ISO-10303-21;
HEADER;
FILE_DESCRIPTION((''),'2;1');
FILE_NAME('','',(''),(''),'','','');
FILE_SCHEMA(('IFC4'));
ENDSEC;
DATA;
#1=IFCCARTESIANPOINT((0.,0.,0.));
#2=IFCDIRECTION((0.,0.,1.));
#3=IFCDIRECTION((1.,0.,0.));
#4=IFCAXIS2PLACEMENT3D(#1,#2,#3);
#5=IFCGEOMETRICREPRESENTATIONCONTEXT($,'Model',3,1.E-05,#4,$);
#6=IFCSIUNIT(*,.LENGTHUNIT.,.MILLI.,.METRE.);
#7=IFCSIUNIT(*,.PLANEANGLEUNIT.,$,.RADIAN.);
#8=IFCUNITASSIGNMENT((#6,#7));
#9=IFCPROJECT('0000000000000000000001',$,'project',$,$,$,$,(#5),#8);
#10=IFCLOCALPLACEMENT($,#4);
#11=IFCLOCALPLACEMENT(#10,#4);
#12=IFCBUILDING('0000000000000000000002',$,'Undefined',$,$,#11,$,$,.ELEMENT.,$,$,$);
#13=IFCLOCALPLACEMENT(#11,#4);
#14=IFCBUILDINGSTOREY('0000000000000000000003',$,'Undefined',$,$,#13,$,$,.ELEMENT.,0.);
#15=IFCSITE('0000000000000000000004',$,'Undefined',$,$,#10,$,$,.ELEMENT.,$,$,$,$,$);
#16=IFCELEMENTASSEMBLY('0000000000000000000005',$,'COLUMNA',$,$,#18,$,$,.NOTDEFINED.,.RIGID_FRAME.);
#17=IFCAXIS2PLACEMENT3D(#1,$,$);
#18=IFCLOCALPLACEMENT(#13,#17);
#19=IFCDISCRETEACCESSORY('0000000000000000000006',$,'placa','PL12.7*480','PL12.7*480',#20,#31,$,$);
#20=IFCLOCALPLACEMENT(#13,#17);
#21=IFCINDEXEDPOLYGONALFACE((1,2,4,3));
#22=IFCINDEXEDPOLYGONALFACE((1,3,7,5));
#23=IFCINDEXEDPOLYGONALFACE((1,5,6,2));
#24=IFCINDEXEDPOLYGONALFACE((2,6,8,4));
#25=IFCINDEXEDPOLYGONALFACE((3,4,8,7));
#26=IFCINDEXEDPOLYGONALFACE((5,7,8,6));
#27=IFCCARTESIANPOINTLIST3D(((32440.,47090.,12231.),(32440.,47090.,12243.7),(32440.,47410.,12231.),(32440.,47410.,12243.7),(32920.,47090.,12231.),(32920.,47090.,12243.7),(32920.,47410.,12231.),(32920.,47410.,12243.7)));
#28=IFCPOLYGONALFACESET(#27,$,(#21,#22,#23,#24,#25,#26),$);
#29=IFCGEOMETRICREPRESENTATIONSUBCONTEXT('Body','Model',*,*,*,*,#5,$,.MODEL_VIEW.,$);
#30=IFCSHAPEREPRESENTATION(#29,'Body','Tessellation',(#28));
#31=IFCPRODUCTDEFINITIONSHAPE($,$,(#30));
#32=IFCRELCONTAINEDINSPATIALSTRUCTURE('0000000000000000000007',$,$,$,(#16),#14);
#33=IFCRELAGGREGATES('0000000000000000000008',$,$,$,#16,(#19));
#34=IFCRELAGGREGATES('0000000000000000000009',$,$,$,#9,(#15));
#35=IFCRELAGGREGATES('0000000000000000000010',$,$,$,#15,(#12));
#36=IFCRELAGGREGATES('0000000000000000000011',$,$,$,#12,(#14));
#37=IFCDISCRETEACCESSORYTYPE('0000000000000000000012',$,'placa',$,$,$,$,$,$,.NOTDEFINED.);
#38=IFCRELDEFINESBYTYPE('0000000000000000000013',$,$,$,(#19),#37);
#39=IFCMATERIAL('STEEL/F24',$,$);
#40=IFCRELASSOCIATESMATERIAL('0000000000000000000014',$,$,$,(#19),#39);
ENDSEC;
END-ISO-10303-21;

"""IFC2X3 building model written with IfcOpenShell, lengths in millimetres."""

from ifc_helpers import new_model, si_unit, frame, origin_with_axes, place, context, subcontext, project, spatial, polyline, outline, extrude, material, type_object, element, aggregate, save


model = new_model("IFC2X3")

# Units and contexts
model_context = context("Model", 3, precision=1e-05, world=origin_with_axes())
body_context = subcontext(model_context, "Body", "Model", "MODEL_VIEW")
ifc_project = project(units=[si_unit("LENGTHUNIT", "METRE", prefix="MILLI"), si_unit("PLANEANGLEUNIT", "RADIAN")], contexts=[model_context])

# Site, building, storey
site_placement = place(None, origin_with_axes())
site = spatial("IfcSite", under=ifc_project, at=site_placement, Name="Undefined", CompositionType="ELEMENT")
building_placement = place(site_placement, origin_with_axes())
building = spatial("IfcBuilding", under=site, at=building_placement, Name="Undefined", CompositionType="ELEMENT")
storey_placement = place(building_placement, origin_with_axes())
storey = spatial("IfcBuildingStorey", under=building, at=storey_placement, Name="Undefined", CompositionType="ELEMENT", Elevation=0.0)

# Shared definitions
ifc_material_1 = material(Name="STEEL/F24")

# Shared definitions
discrete_accessory_type_1 = type_object("IfcDiscreteAccessoryType", Name="placa")

# Element assembly, discrete accessory
assembly_1_placement = place(storey_placement, origin_with_axes())
assembly_1 = element("IfcElementAssembly", 1, at=assembly_1_placement, inside=storey, Name="COLUMNA", AssemblyPlace="NOTDEFINED", PredefinedType="RIGID_FRAME")
discrete_accessory_1_placement = place(assembly_1_placement, frame((32680.0, 47410.0, 12237.4), z_axis=(0.0, 0.0, 1.0), x_axis=(0.0, -1.0, 0.0)))
discrete_accessory_1 = element("IfcDiscreteAccessory", 2, at=discrete_accessory_1_placement, type_object=discrete_accessory_type_1, material=ifc_material_1, Name="placa", Description="PL12.7*480", ObjectType="PL12.7*480", context=body_context, shape_type="SweptSolid", body=[
    extrude(outline(polyline([(320.0, -240.0), (0.0, -240.0), (0.0, 240.0), (320.0, 240.0), (320.0, -240.0)])), frame((0.0, 0.0, -6.3), z_axis=(0.0, 0.0, 1.0), x_axis=(1.0, 0.0, 0.0)), (0.0, 0.0, 1.0), 12.7),
])
aggregate(assembly_1, [discrete_accessory_1])

save(model, "model.ifc")
